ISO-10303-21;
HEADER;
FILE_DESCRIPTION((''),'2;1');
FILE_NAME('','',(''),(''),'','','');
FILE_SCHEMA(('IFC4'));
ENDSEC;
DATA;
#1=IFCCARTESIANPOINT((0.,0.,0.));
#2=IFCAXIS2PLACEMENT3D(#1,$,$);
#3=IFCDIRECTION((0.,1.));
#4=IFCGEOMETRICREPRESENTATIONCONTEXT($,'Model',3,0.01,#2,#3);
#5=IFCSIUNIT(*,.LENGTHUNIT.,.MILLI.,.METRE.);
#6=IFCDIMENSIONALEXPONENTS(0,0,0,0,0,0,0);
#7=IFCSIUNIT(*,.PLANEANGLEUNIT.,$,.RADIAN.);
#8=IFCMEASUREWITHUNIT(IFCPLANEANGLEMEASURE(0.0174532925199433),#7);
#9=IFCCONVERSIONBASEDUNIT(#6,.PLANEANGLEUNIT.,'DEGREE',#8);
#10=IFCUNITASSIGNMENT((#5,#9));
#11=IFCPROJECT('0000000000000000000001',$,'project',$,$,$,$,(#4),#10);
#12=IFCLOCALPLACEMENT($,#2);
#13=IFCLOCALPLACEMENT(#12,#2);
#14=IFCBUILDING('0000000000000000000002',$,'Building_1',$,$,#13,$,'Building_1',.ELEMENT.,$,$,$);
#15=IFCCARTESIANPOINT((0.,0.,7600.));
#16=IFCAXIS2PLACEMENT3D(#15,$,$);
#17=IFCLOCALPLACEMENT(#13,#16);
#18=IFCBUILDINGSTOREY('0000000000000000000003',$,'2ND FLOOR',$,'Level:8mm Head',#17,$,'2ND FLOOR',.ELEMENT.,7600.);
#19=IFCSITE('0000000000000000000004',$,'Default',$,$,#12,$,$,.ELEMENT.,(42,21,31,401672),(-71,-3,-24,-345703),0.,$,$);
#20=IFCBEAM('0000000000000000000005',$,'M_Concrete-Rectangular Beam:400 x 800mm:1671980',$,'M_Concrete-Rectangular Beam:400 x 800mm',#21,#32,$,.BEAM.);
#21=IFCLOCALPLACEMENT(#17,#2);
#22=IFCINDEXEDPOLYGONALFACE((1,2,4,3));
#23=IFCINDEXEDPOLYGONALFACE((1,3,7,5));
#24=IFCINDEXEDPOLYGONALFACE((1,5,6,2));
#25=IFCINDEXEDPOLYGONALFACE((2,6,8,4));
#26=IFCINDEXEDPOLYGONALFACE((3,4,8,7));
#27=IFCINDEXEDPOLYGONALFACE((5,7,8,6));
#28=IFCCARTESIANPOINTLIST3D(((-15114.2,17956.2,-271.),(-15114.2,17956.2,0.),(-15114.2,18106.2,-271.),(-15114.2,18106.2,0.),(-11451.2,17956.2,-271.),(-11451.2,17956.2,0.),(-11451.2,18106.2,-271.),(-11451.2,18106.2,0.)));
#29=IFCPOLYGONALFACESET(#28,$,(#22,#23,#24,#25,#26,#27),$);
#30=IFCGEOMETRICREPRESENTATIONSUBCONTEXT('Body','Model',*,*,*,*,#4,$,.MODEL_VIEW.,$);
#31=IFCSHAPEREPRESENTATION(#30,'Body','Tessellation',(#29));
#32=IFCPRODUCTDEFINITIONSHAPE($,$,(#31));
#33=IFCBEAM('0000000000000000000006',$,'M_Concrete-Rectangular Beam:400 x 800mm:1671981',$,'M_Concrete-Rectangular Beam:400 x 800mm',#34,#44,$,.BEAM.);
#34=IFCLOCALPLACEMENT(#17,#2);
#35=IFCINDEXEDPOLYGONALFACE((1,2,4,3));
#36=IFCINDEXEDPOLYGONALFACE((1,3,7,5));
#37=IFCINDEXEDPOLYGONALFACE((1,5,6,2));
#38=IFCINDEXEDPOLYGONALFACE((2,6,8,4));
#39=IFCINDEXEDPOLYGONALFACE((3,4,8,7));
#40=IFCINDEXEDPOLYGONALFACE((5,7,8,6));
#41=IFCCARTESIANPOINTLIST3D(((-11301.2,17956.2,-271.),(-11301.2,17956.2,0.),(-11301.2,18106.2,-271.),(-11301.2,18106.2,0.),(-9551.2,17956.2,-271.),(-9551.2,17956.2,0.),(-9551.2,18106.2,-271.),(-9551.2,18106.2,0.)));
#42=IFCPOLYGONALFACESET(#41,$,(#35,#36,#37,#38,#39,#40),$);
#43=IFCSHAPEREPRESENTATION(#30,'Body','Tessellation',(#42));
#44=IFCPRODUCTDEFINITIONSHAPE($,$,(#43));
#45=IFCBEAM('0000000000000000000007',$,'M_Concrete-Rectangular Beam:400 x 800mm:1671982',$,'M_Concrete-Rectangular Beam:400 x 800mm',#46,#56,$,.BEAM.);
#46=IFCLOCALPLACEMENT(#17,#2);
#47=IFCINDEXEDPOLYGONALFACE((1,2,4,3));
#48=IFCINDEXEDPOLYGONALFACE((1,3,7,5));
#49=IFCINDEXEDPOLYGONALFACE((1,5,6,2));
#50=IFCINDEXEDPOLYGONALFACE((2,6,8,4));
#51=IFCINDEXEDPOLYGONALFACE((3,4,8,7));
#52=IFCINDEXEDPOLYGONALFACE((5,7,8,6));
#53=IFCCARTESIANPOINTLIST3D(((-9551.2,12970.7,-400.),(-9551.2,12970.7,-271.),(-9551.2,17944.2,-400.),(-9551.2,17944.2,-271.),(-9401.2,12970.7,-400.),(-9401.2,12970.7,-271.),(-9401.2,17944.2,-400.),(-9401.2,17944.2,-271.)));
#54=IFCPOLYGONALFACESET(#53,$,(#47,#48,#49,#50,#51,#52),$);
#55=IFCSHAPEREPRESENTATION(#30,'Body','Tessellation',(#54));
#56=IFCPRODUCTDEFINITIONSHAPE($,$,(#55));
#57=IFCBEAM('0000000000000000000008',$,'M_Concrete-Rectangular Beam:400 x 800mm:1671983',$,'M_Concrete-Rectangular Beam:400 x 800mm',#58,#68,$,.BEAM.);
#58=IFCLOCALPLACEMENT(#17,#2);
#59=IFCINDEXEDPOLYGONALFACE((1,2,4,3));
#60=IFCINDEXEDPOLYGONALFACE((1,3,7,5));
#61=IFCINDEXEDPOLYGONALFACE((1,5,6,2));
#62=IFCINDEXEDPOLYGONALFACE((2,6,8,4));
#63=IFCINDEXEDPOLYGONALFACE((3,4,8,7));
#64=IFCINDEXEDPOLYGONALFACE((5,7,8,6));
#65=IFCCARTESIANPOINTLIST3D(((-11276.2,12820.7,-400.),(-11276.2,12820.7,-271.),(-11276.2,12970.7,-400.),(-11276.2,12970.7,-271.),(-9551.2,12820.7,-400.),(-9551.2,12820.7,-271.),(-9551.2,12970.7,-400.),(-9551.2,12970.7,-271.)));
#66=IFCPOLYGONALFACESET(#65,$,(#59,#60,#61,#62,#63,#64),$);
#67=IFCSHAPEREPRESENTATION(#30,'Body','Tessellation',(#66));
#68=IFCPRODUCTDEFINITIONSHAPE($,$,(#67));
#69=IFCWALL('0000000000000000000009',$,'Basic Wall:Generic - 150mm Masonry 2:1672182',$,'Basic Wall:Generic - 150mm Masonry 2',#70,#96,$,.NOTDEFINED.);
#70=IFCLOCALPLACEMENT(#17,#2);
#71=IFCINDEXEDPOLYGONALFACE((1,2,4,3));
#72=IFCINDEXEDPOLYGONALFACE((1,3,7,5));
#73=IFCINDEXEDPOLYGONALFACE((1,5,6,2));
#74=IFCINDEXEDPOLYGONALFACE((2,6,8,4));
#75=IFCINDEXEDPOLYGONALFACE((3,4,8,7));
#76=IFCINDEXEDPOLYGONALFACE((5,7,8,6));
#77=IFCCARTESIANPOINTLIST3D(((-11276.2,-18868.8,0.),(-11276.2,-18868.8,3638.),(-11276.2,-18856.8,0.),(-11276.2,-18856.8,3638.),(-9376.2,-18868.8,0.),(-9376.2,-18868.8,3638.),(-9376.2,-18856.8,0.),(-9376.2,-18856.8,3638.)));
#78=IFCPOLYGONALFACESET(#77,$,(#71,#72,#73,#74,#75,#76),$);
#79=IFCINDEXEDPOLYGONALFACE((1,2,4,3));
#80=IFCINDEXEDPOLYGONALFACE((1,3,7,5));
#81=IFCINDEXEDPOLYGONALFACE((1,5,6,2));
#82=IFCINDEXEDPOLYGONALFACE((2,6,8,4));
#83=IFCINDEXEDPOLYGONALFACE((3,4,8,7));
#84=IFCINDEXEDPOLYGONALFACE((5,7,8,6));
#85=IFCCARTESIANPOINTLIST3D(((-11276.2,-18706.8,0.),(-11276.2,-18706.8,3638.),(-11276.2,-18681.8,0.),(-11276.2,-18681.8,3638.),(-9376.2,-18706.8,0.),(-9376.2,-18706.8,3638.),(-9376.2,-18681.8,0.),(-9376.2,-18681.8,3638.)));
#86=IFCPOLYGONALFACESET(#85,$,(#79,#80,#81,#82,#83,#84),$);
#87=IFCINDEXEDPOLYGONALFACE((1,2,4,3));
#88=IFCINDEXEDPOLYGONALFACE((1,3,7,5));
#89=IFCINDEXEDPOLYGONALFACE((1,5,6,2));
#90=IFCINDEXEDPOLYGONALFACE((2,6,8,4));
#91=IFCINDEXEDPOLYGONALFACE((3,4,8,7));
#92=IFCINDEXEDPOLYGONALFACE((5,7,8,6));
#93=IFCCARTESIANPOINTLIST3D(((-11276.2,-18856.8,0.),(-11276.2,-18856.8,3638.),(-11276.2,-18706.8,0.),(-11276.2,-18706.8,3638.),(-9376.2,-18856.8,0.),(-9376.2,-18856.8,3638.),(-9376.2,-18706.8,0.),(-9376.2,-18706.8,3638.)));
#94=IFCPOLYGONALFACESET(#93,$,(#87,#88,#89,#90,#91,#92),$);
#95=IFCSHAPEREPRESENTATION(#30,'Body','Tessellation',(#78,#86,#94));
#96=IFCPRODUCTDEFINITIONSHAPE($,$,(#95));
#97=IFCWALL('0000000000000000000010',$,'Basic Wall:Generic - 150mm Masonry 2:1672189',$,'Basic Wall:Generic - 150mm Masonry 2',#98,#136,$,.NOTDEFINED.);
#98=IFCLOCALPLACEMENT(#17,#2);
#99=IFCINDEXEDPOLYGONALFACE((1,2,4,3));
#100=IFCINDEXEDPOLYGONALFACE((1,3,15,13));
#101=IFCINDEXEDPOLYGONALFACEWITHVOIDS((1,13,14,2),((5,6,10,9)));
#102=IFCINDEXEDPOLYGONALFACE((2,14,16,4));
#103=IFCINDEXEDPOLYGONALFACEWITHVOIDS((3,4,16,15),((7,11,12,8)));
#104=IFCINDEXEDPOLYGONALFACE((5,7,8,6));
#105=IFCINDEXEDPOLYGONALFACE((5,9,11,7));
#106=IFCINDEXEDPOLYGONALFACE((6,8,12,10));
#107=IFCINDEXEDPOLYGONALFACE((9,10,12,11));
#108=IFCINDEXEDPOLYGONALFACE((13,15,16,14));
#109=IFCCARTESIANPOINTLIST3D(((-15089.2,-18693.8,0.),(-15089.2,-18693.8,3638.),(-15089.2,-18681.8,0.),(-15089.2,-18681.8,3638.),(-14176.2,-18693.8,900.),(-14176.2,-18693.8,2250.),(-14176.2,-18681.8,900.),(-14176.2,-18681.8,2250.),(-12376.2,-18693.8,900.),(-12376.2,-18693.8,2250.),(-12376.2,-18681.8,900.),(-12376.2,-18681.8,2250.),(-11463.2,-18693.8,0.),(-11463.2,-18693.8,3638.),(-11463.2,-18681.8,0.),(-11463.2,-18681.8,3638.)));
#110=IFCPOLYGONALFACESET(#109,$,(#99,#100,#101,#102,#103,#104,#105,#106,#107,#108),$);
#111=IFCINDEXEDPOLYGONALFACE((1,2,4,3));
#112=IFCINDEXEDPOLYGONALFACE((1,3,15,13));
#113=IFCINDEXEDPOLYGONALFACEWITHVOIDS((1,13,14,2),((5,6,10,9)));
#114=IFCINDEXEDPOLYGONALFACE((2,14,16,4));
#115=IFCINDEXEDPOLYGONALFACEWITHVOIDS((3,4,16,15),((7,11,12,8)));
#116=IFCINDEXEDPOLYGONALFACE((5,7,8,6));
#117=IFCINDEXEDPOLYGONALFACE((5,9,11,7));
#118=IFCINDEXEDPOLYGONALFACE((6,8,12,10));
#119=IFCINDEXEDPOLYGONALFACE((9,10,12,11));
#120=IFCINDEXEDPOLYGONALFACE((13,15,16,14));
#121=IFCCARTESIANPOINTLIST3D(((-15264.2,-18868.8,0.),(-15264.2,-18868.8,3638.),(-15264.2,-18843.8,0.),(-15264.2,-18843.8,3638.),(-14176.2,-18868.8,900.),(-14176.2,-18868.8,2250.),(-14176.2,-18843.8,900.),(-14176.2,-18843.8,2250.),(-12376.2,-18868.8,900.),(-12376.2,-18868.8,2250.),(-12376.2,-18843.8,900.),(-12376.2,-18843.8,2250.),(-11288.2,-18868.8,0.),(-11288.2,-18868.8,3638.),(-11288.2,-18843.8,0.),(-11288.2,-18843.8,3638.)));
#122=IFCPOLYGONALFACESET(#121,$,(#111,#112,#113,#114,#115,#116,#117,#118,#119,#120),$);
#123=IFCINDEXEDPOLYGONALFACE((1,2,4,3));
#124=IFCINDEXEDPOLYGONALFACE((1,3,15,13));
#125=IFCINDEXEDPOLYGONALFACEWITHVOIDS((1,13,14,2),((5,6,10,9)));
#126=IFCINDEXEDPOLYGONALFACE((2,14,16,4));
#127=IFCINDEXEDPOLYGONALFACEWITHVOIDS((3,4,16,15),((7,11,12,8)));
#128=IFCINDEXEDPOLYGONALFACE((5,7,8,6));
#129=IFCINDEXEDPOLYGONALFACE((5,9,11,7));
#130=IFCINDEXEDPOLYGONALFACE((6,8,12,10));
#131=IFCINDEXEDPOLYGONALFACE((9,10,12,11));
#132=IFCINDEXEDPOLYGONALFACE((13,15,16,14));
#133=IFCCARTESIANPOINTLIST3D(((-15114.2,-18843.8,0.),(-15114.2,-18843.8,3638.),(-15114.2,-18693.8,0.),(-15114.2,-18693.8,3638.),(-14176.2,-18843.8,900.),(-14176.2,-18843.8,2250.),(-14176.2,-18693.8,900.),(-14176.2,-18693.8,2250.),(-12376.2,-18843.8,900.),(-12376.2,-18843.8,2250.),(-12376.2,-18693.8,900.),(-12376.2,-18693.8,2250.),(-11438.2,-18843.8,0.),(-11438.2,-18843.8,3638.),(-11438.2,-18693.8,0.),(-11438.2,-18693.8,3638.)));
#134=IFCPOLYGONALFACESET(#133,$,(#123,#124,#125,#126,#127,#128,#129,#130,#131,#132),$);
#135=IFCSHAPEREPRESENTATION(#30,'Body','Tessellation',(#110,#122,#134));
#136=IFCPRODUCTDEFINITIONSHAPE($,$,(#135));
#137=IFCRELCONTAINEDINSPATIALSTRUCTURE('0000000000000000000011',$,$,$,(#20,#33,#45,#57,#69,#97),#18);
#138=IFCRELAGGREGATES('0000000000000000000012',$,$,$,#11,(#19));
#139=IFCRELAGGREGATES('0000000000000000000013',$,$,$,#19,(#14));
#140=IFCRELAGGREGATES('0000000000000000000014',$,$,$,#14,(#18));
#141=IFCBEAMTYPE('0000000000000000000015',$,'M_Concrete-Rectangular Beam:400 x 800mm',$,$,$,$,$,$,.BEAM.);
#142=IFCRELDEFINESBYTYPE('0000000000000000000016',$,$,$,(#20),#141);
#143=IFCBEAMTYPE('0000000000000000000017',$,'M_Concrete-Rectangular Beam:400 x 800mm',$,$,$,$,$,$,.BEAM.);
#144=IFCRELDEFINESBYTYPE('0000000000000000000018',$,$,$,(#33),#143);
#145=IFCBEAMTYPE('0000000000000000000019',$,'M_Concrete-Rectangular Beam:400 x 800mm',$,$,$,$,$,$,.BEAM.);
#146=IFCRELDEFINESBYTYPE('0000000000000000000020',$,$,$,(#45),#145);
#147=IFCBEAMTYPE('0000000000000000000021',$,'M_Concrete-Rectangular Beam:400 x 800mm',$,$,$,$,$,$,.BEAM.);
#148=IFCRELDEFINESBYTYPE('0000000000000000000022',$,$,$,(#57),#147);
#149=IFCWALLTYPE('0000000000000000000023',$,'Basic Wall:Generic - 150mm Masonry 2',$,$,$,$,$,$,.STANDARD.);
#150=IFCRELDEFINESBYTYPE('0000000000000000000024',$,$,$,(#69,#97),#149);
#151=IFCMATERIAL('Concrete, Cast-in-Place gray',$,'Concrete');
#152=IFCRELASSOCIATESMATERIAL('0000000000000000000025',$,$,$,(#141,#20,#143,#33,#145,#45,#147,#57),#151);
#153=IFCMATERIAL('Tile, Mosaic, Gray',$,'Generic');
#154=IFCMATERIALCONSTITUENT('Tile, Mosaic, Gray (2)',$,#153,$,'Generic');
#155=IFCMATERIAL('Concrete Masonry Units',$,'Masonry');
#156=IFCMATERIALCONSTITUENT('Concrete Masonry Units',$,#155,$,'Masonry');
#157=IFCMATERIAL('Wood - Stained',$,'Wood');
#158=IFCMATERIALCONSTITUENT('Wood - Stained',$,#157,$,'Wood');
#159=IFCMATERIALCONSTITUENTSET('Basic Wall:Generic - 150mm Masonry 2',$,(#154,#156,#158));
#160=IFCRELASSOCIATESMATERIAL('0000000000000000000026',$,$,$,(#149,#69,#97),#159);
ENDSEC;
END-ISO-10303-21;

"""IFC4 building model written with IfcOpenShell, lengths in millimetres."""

from ifc_helpers import new_model, entity, si_unit, converted_unit, direction, frame, origin, place, context, subcontext, project, spatial, indexed_curve, outline, extrude, source, transform, mapped, material, constituent, constituent_set, type_object, type_shapes, element, save


model = new_model("IFC4")

# Units and contexts
model_context = context("Model", 3, precision=0.01, world=origin(), true_north=direction((0.0, 1.0)))
body_context = subcontext(model_context, "Body", "Model", "MODEL_VIEW")
ifc_project = project(units=[si_unit("LENGTHUNIT", "METRE", prefix="MILLI"), converted_unit("PLANEANGLEUNIT", "DEGREE", entity("IfcPlaneAngleMeasure", 0.0174532925199433), si_unit("PLANEANGLEUNIT", "RADIAN"), dimensions=[0, 0, 0, 0, 0, 0, 0])], contexts=[model_context])

# Site, building, storey
site_placement = place(None, origin())
site = spatial("IfcSite", under=ifc_project, at=site_placement, Name="Default", CompositionType="ELEMENT", RefLatitude=(42, 21, 31, 401672), RefLongitude=(-71, -3, -24, -345703), RefElevation=0.0)
building_placement = place(site_placement, origin())
building = spatial("IfcBuilding", under=site, at=building_placement, Name="Building_1", LongName="Building_1", CompositionType="ELEMENT")
storey_placement = place(building_placement, frame((0.0, 0.0, 7600.0)))
storey = spatial("IfcBuildingStorey", under=building, at=storey_placement, Name="2ND FLOOR", ObjectType="Level:8mm Head", LongName="2ND FLOOR", CompositionType="ELEMENT", Elevation=7600.0)

# Beams
ifc_material_1 = material(Name="Concrete, Cast-in-Place gray", Category="Concrete")
beam_type_1 = type_object("IfcBeamType", Name="M_Concrete-Rectangular Beam:400 x 800mm", PredefinedType="BEAM", material=ifc_material_1)
shared_shape_1 = source(origin(), body_context, "Body", "SweptSolid", [
    extrude(outline(indexed_curve([(-135.5, -75.0), (135.5, -75.0), (135.5, 75.0), (-135.5, 75.0), (-135.5, -75.0)], self_intersect=False)), frame((-15114.2, 18031.2, 7464.5), z_axis=(1.0, 0.0, 0.0), x_axis=(0.0, 0.0, -1.0)), (0.0, 0.0, 1.0), 3663.0),
])
type_shapes(beam_type_1, [shared_shape_1])
beam_1_placement = place(storey_placement, frame((0.0, 0.0, -7600.0)))
element("IfcBeam", 1, at=beam_1_placement, inside=storey, type_object=beam_type_1, material=ifc_material_1, Name="M_Concrete-Rectangular Beam:400 x 800mm:1671980", ObjectType="M_Concrete-Rectangular Beam:400 x 800mm", PredefinedType="BEAM", context=body_context, shape_type="MappedRepresentation", body=[
    mapped(shared_shape_1, transform((0.0, 0.0, 0.0), scale=1.0)),
])
beam_type_2 = type_object("IfcBeamType", Name="M_Concrete-Rectangular Beam:400 x 800mm", PredefinedType="BEAM", material=ifc_material_1)
shared_shape_2 = source(origin(), body_context, "Body", "SweptSolid", [
    extrude(outline(indexed_curve([(-135.5, -75.0), (135.5, -75.0), (135.5, 75.0), (-135.5, 75.0), (-135.5, -75.0)], self_intersect=False)), frame((-11301.2, 18031.2, 7464.5), z_axis=(1.0, 0.0, 0.0), x_axis=(0.0, 0.0, -1.0)), (0.0, 0.0, 1.0), 1750.0),
])
type_shapes(beam_type_2, [shared_shape_2])
beam_2_placement = place(storey_placement, frame((0.0, 0.0, -7600.0)))
element("IfcBeam", 2, at=beam_2_placement, inside=storey, type_object=beam_type_2, material=ifc_material_1, Name="M_Concrete-Rectangular Beam:400 x 800mm:1671981", ObjectType="M_Concrete-Rectangular Beam:400 x 800mm", PredefinedType="BEAM", context=body_context, shape_type="MappedRepresentation", body=[
    mapped(shared_shape_2, transform((0.0, 0.0, 0.0), scale=1.0)),
])
beam_type_3 = type_object("IfcBeamType", Name="M_Concrete-Rectangular Beam:400 x 800mm", PredefinedType="BEAM", material=ifc_material_1)
shared_shape_3 = source(origin(), body_context, "Body", "SweptSolid", [
    extrude(outline(indexed_curve([(-75.0, -64.5), (75.0, -64.5), (75.0, 64.5), (-75.0, 64.5), (-75.0, -64.5)], self_intersect=False)), frame((-9476.2, 17944.2, 7264.5), z_axis=(0.0, -1.0, 0.0), x_axis=(-1.0, 0.0, 0.0)), (0.0, 0.0, 1.0), 4973.5),
])
type_shapes(beam_type_3, [shared_shape_3])
beam_3_placement = place(storey_placement, frame((0.0, 0.0, -7600.0)))
element("IfcBeam", 3, at=beam_3_placement, inside=storey, type_object=beam_type_3, material=ifc_material_1, Name="M_Concrete-Rectangular Beam:400 x 800mm:1671982", ObjectType="M_Concrete-Rectangular Beam:400 x 800mm", PredefinedType="BEAM", context=body_context, shape_type="MappedRepresentation", body=[
    mapped(shared_shape_3, transform((0.0, 0.0, 0.0), scale=1.0)),
])
beam_type_4 = type_object("IfcBeamType", Name="M_Concrete-Rectangular Beam:400 x 800mm", PredefinedType="BEAM", material=ifc_material_1)
shared_shape_4 = source(origin(), body_context, "Body", "SweptSolid", [
    extrude(outline(indexed_curve([(-64.5, -75.0), (64.5, -75.0), (64.5, 75.0), (-64.5, 75.0), (-64.5, -75.0)], self_intersect=False)), frame((-9551.2, 12895.7, 7264.5), z_axis=(-1.0, 0.0, 0.0), x_axis=(0.0, 0.0, -1.0)), (0.0, 0.0, 1.0), 1725.0),
])
type_shapes(beam_type_4, [shared_shape_4])
beam_4_placement = place(storey_placement, frame((0.0, 0.0, -7600.0)))
element("IfcBeam", 4, at=beam_4_placement, inside=storey, type_object=beam_type_4, material=ifc_material_1, Name="M_Concrete-Rectangular Beam:400 x 800mm:1671983", ObjectType="M_Concrete-Rectangular Beam:400 x 800mm", PredefinedType="BEAM", context=body_context, shape_type="MappedRepresentation", body=[
    mapped(shared_shape_4, transform((0.0, 0.0, 0.0), scale=1.0)),
])

# Wall
ifc_material_2 = material(Name="Tile, Mosaic, Gray", Category="Generic")
ifc_constituent_1 = constituent(ifc_material_2, Name="Tile, Mosaic, Gray (2)", Category="Generic")
ifc_material_3 = material(Name="Concrete Masonry Units", Category="Masonry")
ifc_constituent_2 = constituent(ifc_material_3, Name="Concrete Masonry Units", Category="Masonry")
ifc_material_4 = material(Name="Wood - Stained", Category="Wood")
ifc_constituent_3 = constituent(ifc_material_4, Name="Wood - Stained", Category="Wood")
ifc_constituent_set_1 = constituent_set(constituents=[ifc_constituent_1, ifc_constituent_2, ifc_constituent_3], Name="Basic Wall:Generic - 150mm Masonry 2")
wall_type_1 = type_object("IfcWallType", Name="Basic Wall:Generic - 150mm Masonry 2", PredefinedType="STANDARD", material=ifc_constituent_set_1)
wall_1_placement = place(storey_placement, frame((-11276.2, -18775.3, 0.0)))
element("IfcWall", 5, at=wall_1_placement, inside=storey, type_object=wall_type_1, material=ifc_constituent_set_1, Name="Basic Wall:Generic - 150mm Masonry 2:1672182", ObjectType="Basic Wall:Generic - 150mm Masonry 2", PredefinedType="NOTDEFINED", context=body_context, shape_type="SweptSolid", body=[
    extrude(outline(indexed_curve([(-6.0, -950.0), (6.0, -950.0), (6.0, 950.0), (-6.0, 950.0), (-6.0, -950.0)], self_intersect=False)), frame((950.0, -87.5, 0.0), z_axis=(0.0, 0.0, 1.0), x_axis=(0.0, 1.0, 0.0)), (0.0, 0.0, 1.0), 3638.0),
    extrude(outline(indexed_curve([(-12.5, -950.0), (12.5, -950.0), (12.5, 950.0), (-12.5, 950.0), (-12.5, -950.0)], self_intersect=False)), frame((950.0, 81.0, 0.0), z_axis=(0.0, 0.0, 1.0), x_axis=(0.0, -1.0, 0.0)), (0.0, 0.0, 1.0), 3638.0),
    extrude(outline(indexed_curve([(-950.0, -75.0), (950.0, -75.0), (950.0, 75.0), (-950.0, 75.0), (-950.0, -75.0)], self_intersect=False)), frame((950.0, -6.5, 0.0)), (0.0, 0.0, 1.0), 3638.0),
])

# Wall, opening
wall_2_placement = place(storey_placement, frame((-11463.2, -18775.3, 0.0), z_axis=(0.0, 0.0, 1.0), x_axis=(-1.0, 0.0, 0.0)))
wall_2 = element("IfcWall", 6, at=wall_2_placement, inside=storey, type_object=wall_type_1, material=ifc_constituent_set_1, Name="Basic Wall:Generic - 150mm Masonry 2:1672189", ObjectType="Basic Wall:Generic - 150mm Masonry 2", PredefinedType="NOTDEFINED", context=body_context, shape_type="SweptSolid", body=[
    extrude(outline(indexed_curve([(-1819.0, -1813.0), (1819.0, -1813.0), (1819.0, 1813.0), (-1819.0, 1813.0), (-1819.0, -1813.0)], self_intersect=False), holes=[indexed_curve([(-919.0, -900.0), (-919.0, 900.0), (431.0, 900.0), (431.0, -900.0), (-919.0, -900.0)], self_intersect=False)]), frame((1813.0, -81.5, 1819.0), z_axis=(0.0, -1.0, 0.0), x_axis=(0.0, 0.0, 1.0)), (0.0, 0.0, 1.0), 12.0),
    extrude(outline(indexed_curve([(-1988.0, -1819.0), (1988.0, -1819.0), (1988.0, 1819.0), (-1988.0, 1819.0), (-1988.0, -1819.0)], self_intersect=False), holes=[indexed_curve([(900.0, 431.0), (900.0, -919.0), (-900.0, -919.0), (-900.0, 431.0), (900.0, 431.0)], self_intersect=False)]), frame((1813.0, 93.5, 1819.0), z_axis=(0.0, -1.0, 0.0), x_axis=(1.0, 0.0, 0.0)), (0.0, 0.0, 1.0), 25.0),
    extrude(outline(indexed_curve([(-1819.0, -1838.0), (1819.0, -1838.0), (1819.0, 1838.0), (-1819.0, 1838.0), (-1819.0, -1838.0)], self_intersect=False), holes=[indexed_curve([(-919.0, -900.0), (-919.0, 900.0), (431.0, 900.0), (431.0, -900.0), (-919.0, -900.0)], self_intersect=False)]), frame((1813.0, 68.5, 1819.0), z_axis=(0.0, -1.0, 0.0), x_axis=(0.0, 0.0, 1.0)), (0.0, 0.0, 1.0), 150.0),
])
opening_placement = place(wall_2_placement, frame((913.0, -93.5, 900.0)))
element("IfcOpeningElement", 7, at=opening_placement, cuts=wall_2, PredefinedType="OPENING", context=body_context, shape_type="SweptSolid", body=[
    extrude(outline(indexed_curve([(1350.0, 1800.0), (0.0, 1800.0), (0.0, 0.0), (1350.0, 0.0), (1350.0, 1800.0)], self_intersect=False)), frame((0.0, 0.0, 0.0), z_axis=(0.0, 1.0, 0.0), x_axis=(0.0, 0.0, 1.0)), (0.0, 0.0, 1.0), 187.0),
])

save(model, "model.ifc")
